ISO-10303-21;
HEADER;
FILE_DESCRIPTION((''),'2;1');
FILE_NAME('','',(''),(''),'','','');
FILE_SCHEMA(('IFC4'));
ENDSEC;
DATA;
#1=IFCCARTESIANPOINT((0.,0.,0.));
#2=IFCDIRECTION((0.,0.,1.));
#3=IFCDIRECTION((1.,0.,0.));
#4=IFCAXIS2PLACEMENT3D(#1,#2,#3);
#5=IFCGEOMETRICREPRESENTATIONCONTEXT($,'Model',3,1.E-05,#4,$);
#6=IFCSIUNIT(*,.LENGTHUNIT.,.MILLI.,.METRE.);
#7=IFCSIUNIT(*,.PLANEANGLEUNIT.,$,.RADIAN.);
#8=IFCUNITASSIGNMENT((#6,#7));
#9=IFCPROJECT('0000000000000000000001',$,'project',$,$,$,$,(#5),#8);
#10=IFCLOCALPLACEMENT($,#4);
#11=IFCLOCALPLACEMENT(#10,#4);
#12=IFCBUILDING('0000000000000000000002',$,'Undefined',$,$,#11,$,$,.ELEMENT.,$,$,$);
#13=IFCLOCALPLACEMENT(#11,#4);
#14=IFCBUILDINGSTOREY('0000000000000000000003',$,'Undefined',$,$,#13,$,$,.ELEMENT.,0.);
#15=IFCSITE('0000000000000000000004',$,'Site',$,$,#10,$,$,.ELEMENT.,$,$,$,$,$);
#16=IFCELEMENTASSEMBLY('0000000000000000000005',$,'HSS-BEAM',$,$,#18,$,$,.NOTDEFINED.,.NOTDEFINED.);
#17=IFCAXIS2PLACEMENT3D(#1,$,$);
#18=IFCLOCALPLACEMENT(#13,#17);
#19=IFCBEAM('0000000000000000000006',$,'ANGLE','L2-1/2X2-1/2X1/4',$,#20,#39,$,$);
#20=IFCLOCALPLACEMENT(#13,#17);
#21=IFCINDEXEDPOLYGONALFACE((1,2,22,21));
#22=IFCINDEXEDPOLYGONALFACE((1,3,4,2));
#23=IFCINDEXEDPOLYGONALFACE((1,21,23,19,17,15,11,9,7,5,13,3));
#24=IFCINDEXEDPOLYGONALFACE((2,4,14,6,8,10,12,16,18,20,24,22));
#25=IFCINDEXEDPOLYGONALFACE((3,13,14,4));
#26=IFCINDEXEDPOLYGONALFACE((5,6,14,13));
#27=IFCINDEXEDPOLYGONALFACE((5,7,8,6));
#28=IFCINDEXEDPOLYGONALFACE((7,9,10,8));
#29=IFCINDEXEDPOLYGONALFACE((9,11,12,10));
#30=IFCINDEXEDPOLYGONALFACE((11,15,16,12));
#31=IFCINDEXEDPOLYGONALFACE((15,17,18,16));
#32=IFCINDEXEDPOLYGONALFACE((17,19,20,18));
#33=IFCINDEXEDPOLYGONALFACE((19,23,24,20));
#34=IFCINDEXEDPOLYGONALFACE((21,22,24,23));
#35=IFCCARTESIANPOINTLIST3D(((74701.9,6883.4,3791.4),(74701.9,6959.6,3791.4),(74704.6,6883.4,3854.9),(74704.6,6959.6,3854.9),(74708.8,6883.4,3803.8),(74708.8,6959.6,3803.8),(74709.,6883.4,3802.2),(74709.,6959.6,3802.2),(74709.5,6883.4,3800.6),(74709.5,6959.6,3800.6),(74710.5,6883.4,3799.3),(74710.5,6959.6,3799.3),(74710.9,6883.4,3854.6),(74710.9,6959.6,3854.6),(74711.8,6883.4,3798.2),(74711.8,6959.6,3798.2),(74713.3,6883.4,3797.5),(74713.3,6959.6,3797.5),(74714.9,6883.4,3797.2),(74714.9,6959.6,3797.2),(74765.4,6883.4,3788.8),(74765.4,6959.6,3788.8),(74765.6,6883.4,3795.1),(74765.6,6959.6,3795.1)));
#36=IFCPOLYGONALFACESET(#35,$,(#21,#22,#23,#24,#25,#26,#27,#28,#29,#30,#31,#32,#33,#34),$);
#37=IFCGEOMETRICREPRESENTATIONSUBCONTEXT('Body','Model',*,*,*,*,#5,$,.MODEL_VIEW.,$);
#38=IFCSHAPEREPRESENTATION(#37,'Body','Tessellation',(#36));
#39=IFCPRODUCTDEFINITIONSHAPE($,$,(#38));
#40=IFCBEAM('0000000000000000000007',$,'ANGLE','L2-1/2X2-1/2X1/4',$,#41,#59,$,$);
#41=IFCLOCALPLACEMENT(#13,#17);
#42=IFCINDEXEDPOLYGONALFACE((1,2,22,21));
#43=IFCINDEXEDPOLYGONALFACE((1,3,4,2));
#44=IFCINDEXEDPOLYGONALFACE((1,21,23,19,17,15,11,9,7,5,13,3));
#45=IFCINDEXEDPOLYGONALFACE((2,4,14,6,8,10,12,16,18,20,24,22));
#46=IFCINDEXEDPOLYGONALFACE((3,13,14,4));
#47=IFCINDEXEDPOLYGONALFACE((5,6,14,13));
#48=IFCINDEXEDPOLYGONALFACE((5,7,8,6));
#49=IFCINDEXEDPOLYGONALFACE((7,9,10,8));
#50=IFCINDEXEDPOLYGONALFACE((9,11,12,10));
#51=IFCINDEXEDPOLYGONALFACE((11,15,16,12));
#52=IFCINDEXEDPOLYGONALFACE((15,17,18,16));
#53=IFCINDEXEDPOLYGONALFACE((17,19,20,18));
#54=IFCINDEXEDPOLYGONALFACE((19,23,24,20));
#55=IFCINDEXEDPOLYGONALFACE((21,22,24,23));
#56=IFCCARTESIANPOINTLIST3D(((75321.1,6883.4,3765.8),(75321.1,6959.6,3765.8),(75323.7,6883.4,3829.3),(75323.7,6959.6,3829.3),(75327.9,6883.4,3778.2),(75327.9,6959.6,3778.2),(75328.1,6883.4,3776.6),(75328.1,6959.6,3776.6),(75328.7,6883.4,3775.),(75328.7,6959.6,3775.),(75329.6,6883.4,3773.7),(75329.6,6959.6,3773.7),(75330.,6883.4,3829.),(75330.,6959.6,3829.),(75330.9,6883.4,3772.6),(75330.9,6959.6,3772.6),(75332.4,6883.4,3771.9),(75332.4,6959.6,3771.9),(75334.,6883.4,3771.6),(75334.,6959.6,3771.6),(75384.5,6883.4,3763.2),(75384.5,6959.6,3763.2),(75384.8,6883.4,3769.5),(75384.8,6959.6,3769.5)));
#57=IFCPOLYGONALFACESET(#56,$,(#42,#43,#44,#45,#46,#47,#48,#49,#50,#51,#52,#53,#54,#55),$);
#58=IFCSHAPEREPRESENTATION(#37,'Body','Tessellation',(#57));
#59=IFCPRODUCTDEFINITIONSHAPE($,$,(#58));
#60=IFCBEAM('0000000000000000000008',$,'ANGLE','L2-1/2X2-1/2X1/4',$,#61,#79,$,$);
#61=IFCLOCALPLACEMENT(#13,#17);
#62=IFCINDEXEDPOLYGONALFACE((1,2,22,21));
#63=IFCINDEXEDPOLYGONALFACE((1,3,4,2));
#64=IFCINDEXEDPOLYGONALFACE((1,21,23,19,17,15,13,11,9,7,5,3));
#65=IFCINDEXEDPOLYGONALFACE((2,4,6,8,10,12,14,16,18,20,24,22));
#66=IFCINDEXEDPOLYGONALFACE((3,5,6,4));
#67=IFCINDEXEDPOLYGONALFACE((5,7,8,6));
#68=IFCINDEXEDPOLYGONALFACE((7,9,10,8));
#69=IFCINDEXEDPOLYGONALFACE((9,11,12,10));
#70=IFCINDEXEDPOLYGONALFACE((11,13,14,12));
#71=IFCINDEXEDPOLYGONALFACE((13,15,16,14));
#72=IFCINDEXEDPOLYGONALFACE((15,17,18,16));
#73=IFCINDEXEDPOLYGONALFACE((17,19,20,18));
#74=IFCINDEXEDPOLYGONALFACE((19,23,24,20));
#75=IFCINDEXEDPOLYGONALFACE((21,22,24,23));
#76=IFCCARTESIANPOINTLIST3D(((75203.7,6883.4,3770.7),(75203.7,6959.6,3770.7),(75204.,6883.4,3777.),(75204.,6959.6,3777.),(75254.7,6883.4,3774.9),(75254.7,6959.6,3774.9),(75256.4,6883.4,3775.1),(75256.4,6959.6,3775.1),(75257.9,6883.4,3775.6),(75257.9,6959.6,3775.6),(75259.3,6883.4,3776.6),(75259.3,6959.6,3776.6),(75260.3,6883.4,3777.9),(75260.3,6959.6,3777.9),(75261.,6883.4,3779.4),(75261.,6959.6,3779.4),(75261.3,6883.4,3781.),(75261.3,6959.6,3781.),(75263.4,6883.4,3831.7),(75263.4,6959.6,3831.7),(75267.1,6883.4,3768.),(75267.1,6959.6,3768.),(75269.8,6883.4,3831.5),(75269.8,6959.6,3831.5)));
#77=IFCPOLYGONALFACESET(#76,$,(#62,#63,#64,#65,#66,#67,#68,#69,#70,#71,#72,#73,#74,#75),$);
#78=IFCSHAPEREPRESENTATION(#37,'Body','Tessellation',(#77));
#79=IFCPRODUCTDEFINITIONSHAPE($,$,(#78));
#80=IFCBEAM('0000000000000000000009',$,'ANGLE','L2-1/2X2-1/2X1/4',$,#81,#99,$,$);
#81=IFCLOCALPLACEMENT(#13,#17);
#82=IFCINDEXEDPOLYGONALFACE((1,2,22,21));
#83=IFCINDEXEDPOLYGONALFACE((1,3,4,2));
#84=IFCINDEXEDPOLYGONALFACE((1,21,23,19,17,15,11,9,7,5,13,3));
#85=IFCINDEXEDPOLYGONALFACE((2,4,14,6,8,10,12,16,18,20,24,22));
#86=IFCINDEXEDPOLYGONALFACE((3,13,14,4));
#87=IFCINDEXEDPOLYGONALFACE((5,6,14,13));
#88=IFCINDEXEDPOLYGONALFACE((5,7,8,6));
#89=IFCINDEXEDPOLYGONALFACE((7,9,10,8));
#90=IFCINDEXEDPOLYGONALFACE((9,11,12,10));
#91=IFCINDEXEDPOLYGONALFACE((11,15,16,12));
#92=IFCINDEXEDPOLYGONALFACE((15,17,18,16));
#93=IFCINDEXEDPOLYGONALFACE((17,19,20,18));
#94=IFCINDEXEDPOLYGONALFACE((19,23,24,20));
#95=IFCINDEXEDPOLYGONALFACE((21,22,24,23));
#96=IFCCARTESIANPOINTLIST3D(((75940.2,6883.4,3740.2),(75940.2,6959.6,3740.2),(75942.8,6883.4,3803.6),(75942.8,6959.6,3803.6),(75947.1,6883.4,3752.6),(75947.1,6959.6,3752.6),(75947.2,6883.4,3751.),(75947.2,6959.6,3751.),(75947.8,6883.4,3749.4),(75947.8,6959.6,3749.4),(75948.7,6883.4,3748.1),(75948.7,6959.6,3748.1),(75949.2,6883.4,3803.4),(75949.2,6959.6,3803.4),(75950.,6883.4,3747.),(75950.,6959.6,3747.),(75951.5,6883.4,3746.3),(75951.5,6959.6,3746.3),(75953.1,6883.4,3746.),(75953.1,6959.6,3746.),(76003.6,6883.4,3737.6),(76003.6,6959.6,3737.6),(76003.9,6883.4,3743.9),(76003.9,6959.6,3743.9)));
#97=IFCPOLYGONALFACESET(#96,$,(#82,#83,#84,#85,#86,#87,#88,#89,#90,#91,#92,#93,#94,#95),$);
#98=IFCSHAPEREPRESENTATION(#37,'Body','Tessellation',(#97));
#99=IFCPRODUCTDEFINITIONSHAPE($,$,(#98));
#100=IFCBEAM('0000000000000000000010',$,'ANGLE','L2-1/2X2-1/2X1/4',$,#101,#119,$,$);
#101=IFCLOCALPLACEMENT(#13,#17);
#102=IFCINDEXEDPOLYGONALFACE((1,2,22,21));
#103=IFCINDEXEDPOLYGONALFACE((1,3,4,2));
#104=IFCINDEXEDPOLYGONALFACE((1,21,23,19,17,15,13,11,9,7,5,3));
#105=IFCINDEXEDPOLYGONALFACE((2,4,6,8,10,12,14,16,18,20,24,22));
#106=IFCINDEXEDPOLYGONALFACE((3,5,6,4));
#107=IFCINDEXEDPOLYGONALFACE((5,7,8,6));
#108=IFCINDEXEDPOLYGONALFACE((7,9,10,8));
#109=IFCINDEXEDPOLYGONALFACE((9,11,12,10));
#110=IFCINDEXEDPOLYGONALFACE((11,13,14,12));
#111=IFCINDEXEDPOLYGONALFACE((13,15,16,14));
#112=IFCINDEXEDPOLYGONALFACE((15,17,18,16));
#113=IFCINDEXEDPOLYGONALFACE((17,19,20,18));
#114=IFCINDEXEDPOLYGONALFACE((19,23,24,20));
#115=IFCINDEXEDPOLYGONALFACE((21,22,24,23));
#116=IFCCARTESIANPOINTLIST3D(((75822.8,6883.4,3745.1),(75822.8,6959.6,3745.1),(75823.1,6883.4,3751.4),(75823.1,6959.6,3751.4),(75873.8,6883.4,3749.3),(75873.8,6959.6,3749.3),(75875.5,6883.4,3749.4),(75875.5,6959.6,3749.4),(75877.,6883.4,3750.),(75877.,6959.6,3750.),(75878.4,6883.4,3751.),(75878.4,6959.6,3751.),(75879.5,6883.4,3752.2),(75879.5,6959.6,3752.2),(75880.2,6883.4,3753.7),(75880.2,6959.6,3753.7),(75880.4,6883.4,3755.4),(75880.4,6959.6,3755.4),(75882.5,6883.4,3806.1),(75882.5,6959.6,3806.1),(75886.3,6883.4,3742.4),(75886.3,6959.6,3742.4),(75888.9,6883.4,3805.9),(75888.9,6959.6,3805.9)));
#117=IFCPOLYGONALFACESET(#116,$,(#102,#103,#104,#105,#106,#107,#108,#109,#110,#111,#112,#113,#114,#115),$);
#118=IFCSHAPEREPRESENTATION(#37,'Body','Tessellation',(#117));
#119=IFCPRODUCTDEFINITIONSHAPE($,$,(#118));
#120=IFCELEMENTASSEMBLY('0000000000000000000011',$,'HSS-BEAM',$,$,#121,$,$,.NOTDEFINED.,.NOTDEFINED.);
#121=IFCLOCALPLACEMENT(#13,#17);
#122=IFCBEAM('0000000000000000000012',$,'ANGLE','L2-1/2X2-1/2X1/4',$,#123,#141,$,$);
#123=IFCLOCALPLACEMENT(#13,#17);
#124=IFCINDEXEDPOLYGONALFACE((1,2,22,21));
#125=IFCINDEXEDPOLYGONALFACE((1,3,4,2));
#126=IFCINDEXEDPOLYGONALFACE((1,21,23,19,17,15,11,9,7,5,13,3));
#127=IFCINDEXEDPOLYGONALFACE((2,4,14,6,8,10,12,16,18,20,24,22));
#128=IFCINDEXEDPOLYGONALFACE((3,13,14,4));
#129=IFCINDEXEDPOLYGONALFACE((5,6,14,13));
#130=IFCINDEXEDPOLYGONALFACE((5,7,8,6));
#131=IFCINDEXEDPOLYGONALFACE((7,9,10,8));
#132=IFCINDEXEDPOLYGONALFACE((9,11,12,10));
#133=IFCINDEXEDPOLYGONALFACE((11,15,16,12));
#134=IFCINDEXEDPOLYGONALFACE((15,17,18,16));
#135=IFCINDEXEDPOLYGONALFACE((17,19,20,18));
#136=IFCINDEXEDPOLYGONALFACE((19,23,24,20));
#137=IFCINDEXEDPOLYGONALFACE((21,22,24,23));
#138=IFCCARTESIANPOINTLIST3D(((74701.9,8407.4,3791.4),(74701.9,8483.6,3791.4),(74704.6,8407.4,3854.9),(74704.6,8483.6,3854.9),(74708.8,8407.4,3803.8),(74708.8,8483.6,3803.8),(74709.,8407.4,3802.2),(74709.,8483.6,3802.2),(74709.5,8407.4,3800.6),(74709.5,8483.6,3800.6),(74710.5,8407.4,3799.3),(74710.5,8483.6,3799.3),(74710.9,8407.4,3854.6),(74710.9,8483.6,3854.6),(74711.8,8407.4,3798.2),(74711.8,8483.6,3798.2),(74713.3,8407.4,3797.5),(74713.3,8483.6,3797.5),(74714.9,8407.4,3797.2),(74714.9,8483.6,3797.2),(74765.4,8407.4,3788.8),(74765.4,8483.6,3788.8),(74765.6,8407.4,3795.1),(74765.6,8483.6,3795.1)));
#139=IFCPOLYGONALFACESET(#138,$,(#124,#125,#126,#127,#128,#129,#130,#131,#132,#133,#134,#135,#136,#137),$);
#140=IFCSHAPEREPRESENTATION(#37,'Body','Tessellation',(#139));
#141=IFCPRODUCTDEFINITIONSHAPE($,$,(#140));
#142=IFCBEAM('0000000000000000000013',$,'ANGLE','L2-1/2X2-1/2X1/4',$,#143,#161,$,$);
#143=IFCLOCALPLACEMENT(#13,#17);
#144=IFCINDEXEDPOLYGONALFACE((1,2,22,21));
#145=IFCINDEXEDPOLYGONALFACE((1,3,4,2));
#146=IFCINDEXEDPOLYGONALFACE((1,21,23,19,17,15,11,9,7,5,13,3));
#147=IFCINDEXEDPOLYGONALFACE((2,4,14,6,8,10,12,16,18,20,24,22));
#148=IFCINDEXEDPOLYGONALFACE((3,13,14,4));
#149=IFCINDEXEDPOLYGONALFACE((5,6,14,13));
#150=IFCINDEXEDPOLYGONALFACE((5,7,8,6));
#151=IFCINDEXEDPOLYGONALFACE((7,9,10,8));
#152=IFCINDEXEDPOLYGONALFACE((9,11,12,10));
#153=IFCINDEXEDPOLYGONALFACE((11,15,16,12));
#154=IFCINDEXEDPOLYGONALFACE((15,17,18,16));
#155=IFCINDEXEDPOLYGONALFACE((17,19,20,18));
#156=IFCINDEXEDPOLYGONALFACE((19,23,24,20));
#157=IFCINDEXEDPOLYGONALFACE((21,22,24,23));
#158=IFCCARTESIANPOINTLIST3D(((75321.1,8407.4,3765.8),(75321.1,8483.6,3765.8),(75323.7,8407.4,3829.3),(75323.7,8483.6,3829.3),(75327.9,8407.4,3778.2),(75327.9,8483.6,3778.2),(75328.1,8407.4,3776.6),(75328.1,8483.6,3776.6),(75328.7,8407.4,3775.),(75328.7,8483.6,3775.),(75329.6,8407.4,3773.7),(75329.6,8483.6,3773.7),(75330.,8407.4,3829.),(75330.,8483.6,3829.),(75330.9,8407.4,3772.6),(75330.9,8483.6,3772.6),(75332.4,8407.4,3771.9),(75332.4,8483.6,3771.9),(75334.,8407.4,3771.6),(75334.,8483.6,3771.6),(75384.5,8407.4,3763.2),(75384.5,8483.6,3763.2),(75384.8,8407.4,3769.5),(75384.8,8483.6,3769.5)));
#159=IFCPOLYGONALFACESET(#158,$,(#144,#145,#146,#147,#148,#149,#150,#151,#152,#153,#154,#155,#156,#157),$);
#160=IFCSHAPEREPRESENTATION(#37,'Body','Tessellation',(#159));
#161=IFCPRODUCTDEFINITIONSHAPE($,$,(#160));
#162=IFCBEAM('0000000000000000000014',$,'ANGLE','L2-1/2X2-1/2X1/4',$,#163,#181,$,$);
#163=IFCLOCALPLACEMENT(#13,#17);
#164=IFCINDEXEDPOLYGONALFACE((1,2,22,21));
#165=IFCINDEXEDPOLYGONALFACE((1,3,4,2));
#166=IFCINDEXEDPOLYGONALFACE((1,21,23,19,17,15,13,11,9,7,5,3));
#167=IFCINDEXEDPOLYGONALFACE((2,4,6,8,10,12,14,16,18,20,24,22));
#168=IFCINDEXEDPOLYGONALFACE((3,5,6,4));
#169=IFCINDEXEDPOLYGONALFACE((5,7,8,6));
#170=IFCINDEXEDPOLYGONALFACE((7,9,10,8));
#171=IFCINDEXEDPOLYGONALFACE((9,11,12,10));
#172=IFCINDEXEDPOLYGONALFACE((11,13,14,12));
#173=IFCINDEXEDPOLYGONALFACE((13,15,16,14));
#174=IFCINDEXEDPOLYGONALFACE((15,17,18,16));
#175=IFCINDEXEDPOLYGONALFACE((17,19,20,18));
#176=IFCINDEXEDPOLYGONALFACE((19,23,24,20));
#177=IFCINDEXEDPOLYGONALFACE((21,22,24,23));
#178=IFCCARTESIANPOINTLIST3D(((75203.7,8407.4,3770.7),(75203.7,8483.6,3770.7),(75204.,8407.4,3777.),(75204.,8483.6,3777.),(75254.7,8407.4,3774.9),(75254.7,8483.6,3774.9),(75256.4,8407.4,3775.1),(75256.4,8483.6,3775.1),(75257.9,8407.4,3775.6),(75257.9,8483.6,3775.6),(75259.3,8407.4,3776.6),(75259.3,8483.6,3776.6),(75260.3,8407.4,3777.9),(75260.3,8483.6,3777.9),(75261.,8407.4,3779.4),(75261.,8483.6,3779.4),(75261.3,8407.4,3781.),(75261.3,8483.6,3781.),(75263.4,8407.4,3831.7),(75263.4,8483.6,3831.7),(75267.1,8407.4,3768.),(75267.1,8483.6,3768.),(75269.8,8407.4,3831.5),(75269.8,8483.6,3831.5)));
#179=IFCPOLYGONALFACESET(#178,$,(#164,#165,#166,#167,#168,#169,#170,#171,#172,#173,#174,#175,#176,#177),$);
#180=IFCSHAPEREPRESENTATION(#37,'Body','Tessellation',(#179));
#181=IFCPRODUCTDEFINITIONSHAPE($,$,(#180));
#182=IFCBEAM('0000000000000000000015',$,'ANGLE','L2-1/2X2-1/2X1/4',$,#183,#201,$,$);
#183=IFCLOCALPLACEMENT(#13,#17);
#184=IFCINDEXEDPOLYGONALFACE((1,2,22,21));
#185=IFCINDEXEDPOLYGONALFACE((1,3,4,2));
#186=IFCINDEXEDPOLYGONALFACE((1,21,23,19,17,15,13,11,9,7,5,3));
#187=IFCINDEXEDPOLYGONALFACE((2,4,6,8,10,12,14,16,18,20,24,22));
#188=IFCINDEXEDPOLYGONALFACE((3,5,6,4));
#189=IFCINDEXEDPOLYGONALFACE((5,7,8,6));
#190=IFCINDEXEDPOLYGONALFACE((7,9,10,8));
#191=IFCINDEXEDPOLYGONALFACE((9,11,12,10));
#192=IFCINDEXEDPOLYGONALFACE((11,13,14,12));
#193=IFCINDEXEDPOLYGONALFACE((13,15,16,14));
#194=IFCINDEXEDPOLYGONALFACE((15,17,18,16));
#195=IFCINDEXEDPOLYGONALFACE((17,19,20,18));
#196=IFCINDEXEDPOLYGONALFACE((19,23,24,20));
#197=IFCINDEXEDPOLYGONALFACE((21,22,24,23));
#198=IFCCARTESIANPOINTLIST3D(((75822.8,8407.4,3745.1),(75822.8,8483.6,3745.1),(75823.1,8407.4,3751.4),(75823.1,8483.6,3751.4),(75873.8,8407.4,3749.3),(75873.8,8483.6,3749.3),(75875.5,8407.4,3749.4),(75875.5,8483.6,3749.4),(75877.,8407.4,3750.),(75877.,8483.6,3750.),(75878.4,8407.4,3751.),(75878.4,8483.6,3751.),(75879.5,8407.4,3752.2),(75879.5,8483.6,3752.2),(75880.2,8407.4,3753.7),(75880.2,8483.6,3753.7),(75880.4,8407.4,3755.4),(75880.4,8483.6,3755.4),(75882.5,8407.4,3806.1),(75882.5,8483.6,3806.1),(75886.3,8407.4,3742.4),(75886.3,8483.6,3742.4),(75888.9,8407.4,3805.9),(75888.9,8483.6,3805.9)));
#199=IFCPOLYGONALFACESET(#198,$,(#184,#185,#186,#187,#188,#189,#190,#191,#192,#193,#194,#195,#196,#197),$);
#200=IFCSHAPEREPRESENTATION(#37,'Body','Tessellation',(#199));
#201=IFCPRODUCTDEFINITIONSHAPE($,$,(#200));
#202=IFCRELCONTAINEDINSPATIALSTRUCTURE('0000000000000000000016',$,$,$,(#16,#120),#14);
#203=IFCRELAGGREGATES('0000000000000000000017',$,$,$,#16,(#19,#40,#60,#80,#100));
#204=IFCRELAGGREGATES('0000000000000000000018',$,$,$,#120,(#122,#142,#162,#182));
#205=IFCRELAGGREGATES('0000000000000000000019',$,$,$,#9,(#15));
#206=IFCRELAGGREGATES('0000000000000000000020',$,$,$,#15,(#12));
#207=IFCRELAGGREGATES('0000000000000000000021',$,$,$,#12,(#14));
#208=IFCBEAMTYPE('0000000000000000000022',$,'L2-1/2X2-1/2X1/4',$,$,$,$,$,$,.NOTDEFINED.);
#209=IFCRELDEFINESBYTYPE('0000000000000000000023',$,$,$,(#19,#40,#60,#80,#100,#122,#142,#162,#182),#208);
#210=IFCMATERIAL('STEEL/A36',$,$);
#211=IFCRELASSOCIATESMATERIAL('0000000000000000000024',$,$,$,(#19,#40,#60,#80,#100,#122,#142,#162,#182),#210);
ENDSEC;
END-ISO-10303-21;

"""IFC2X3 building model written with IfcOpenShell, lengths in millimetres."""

from ifc_helpers import new_model, si_unit, frame, origin_with_axes, origin_2d_with_axis, place, context, subcontext, project, spatial, l_section, extrude, material, type_object, element, aggregate, save


model = new_model("IFC2X3")

# Units and contexts
model_context = context("Model", 3, precision=1e-05, world=origin_with_axes())
body_context = subcontext(model_context, "Body", "Model", "MODEL_VIEW")
ifc_project = project(units=[si_unit("LENGTHUNIT", "METRE", prefix="MILLI"), si_unit("PLANEANGLEUNIT", "RADIAN")], contexts=[model_context])

# Site, building, storey
site_placement = place(None, origin_with_axes())
site = spatial("IfcSite", under=ifc_project, at=site_placement, Name="Site", CompositionType="ELEMENT")
building_placement = place(site_placement, origin_with_axes())
building = spatial("IfcBuilding", under=site, at=building_placement, Name="Undefined", CompositionType="ELEMENT")
storey_placement = place(building_placement, origin_with_axes())
storey = spatial("IfcBuildingStorey", under=building, at=storey_placement, Name="Undefined", CompositionType="ELEMENT", Elevation=0.0)

# Element assemblies, beams
assembly_1_placement = place(storey_placement, origin_with_axes())
assembly_1 = element("IfcElementAssembly", 1, at=assembly_1_placement, inside=storey, Name="HSS-BEAM", AssemblyPlace="NOTDEFINED", PredefinedType="NOTDEFINED")
ifc_material_1 = material(Name="STEEL/A36")
beam_type_1 = type_object("IfcBeamType", Name="L2-1/2X2-1/2X1/4", PredefinedType="NOTDEFINED")
beam_1_placement = place(assembly_1_placement, frame((74735.0, 6959.6, 3821.8), z_axis=(0.999145, 0.0, -0.041337), x_axis=(0.0, -1.0, 0.0)))
beam_1 = element("IfcBeam", 2, at=beam_1_placement, type_object=beam_type_1, material=ifc_material_1, Name="ANGLE", Description="L2-1/2X2-1/2X1/4", context=body_context, shape_type="SweptSolid", body=[
    extrude(l_section(Depth=63.5, Width=63.5, Thickness=6.3, FilletRadius=6.3, at=origin_2d_with_axis()), frame((76.2, 0.0, 0.0), z_axis=(-1.0, 0.0, 0.0), x_axis=(0.0, -1.0, 0.0)), (0.0, 0.0, 1.0), 76.2),
])
beam_2_placement = place(assembly_1_placement, frame((75354.1, 6959.6, 3796.2), z_axis=(0.999145, 0.0, -0.041337), x_axis=(0.0, -1.0, 0.0)))
beam_2 = element("IfcBeam", 3, at=beam_2_placement, type_object=beam_type_1, material=ifc_material_1, Name="ANGLE", Description="L2-1/2X2-1/2X1/4", context=body_context, shape_type="SweptSolid", body=[
    extrude(l_section(Depth=63.5, Width=63.5, Thickness=6.3, FilletRadius=6.3, at=origin_2d_with_axis()), frame((76.2, 0.0, 0.0), z_axis=(-1.0, 0.0, 0.0), x_axis=(0.0, -1.0, 0.0)), (0.0, 0.0, 1.0), 76.2),
])
beam_3_placement = place(assembly_1_placement, frame((75236.7, 6883.4, 3801.1), z_axis=(-0.999145, 0.0, 0.041337), x_axis=(0.0, 1.0, 0.0)))
beam_3 = element("IfcBeam", 4, at=beam_3_placement, type_object=beam_type_1, material=ifc_material_1, Name="ANGLE", Description="L2-1/2X2-1/2X1/4", context=body_context, shape_type="SweptSolid", body=[
    extrude(l_section(Depth=63.5, Width=63.5, Thickness=6.3, FilletRadius=6.3, at=origin_2d_with_axis()), frame((76.2, 0.0, 0.0), z_axis=(-1.0, 0.0, 0.0), x_axis=(0.0, -1.0, 0.0)), (0.0, 0.0, 1.0), 76.2),
])
beam_4_placement = place(assembly_1_placement, frame((75973.2, 6959.6, 3770.6), z_axis=(0.999145, 0.0, -0.041337), x_axis=(0.0, -1.0, 0.0)))
beam_4 = element("IfcBeam", 5, at=beam_4_placement, type_object=beam_type_1, material=ifc_material_1, Name="ANGLE", Description="L2-1/2X2-1/2X1/4", context=body_context, shape_type="SweptSolid", body=[
    extrude(l_section(Depth=63.5, Width=63.5, Thickness=6.3, FilletRadius=6.3, at=origin_2d_with_axis()), frame((76.2, 0.0, 0.0), z_axis=(-1.0, 0.0, 0.0), x_axis=(0.0, -1.0, 0.0)), (0.0, 0.0, 1.0), 76.2),
])
beam_5_placement = place(assembly_1_placement, frame((75855.9, 6883.4, 3775.5), z_axis=(-0.999145, 0.0, 0.041337), x_axis=(0.0, 1.0, 0.0)))
beam_5 = element("IfcBeam", 6, at=beam_5_placement, type_object=beam_type_1, material=ifc_material_1, Name="ANGLE", Description="L2-1/2X2-1/2X1/4", context=body_context, shape_type="SweptSolid", body=[
    extrude(l_section(Depth=63.5, Width=63.5, Thickness=6.3, FilletRadius=6.3, at=origin_2d_with_axis()), frame((76.2, 0.0, 0.0), z_axis=(-1.0, 0.0, 0.0), x_axis=(0.0, -1.0, 0.0)), (0.0, 0.0, 1.0), 76.2),
])
aggregate(assembly_1, [beam_1, beam_2, beam_3, beam_4, beam_5])
assembly_2_placement = place(storey_placement, origin_with_axes())
assembly_2 = element("IfcElementAssembly", 7, at=assembly_2_placement, inside=storey, Name="HSS-BEAM", AssemblyPlace="NOTDEFINED", PredefinedType="NOTDEFINED")
beam_6_placement = place(assembly_2_placement, frame((74735.0, 8483.6, 3821.8), z_axis=(0.999145, 0.0, -0.041337), x_axis=(0.0, -1.0, 0.0)))
beam_6 = element("IfcBeam", 8, at=beam_6_placement, type_object=beam_type_1, material=ifc_material_1, Name="ANGLE", Description="L2-1/2X2-1/2X1/4", context=body_context, shape_type="SweptSolid", body=[
    extrude(l_section(Depth=63.5, Width=63.5, Thickness=6.3, FilletRadius=6.3, at=origin_2d_with_axis()), frame((76.2, 0.0, 0.0), z_axis=(-1.0, 0.0, 0.0), x_axis=(0.0, -1.0, 0.0)), (0.0, 0.0, 1.0), 76.2),
])
beam_7_placement = place(assembly_2_placement, frame((75354.1, 8483.6, 3796.2), z_axis=(0.999145, 0.0, -0.041337), x_axis=(0.0, -1.0, 0.0)))
beam_7 = element("IfcBeam", 9, at=beam_7_placement, type_object=beam_type_1, material=ifc_material_1, Name="ANGLE", Description="L2-1/2X2-1/2X1/4", context=body_context, shape_type="SweptSolid", body=[
    extrude(l_section(Depth=63.5, Width=63.5, Thickness=6.3, FilletRadius=6.3, at=origin_2d_with_axis()), frame((76.2, 0.0, 0.0), z_axis=(-1.0, 0.0, 0.0), x_axis=(0.0, -1.0, 0.0)), (0.0, 0.0, 1.0), 76.2),
])
beam_8_placement = place(assembly_2_placement, frame((75236.7, 8407.4, 3801.1), z_axis=(-0.999145, 0.0, 0.041337), x_axis=(0.0, 1.0, 0.0)))
beam_8 = element("IfcBeam", 10, at=beam_8_placement, type_object=beam_type_1, material=ifc_material_1, Name="ANGLE", Description="L2-1/2X2-1/2X1/4", context=body_context, shape_type="SweptSolid", body=[
    extrude(l_section(Depth=63.5, Width=63.5, Thickness=6.3, FilletRadius=6.3, at=origin_2d_with_axis()), frame((76.2, 0.0, 0.0), z_axis=(-1.0, 0.0, 0.0), x_axis=(0.0, -1.0, 0.0)), (0.0, 0.0, 1.0), 76.2),
])
beam_9_placement = place(assembly_2_placement, frame((75855.9, 8407.4, 3775.5), z_axis=(-0.999145, 0.0, 0.041337), x_axis=(0.0, 1.0, 0.0)))
beam_9 = element("IfcBeam", 11, at=beam_9_placement, type_object=beam_type_1, material=ifc_material_1, Name="ANGLE", Description="L2-1/2X2-1/2X1/4", context=body_context, shape_type="SweptSolid", body=[
    extrude(l_section(Depth=63.5, Width=63.5, Thickness=6.3, FilletRadius=6.3, at=origin_2d_with_axis()), frame((76.2, 0.0, 0.0), z_axis=(-1.0, 0.0, 0.0), x_axis=(0.0, -1.0, 0.0)), (0.0, 0.0, 1.0), 76.2),
])
aggregate(assembly_2, [beam_6, beam_7, beam_8, beam_9])

save(model, "model.ifc")
